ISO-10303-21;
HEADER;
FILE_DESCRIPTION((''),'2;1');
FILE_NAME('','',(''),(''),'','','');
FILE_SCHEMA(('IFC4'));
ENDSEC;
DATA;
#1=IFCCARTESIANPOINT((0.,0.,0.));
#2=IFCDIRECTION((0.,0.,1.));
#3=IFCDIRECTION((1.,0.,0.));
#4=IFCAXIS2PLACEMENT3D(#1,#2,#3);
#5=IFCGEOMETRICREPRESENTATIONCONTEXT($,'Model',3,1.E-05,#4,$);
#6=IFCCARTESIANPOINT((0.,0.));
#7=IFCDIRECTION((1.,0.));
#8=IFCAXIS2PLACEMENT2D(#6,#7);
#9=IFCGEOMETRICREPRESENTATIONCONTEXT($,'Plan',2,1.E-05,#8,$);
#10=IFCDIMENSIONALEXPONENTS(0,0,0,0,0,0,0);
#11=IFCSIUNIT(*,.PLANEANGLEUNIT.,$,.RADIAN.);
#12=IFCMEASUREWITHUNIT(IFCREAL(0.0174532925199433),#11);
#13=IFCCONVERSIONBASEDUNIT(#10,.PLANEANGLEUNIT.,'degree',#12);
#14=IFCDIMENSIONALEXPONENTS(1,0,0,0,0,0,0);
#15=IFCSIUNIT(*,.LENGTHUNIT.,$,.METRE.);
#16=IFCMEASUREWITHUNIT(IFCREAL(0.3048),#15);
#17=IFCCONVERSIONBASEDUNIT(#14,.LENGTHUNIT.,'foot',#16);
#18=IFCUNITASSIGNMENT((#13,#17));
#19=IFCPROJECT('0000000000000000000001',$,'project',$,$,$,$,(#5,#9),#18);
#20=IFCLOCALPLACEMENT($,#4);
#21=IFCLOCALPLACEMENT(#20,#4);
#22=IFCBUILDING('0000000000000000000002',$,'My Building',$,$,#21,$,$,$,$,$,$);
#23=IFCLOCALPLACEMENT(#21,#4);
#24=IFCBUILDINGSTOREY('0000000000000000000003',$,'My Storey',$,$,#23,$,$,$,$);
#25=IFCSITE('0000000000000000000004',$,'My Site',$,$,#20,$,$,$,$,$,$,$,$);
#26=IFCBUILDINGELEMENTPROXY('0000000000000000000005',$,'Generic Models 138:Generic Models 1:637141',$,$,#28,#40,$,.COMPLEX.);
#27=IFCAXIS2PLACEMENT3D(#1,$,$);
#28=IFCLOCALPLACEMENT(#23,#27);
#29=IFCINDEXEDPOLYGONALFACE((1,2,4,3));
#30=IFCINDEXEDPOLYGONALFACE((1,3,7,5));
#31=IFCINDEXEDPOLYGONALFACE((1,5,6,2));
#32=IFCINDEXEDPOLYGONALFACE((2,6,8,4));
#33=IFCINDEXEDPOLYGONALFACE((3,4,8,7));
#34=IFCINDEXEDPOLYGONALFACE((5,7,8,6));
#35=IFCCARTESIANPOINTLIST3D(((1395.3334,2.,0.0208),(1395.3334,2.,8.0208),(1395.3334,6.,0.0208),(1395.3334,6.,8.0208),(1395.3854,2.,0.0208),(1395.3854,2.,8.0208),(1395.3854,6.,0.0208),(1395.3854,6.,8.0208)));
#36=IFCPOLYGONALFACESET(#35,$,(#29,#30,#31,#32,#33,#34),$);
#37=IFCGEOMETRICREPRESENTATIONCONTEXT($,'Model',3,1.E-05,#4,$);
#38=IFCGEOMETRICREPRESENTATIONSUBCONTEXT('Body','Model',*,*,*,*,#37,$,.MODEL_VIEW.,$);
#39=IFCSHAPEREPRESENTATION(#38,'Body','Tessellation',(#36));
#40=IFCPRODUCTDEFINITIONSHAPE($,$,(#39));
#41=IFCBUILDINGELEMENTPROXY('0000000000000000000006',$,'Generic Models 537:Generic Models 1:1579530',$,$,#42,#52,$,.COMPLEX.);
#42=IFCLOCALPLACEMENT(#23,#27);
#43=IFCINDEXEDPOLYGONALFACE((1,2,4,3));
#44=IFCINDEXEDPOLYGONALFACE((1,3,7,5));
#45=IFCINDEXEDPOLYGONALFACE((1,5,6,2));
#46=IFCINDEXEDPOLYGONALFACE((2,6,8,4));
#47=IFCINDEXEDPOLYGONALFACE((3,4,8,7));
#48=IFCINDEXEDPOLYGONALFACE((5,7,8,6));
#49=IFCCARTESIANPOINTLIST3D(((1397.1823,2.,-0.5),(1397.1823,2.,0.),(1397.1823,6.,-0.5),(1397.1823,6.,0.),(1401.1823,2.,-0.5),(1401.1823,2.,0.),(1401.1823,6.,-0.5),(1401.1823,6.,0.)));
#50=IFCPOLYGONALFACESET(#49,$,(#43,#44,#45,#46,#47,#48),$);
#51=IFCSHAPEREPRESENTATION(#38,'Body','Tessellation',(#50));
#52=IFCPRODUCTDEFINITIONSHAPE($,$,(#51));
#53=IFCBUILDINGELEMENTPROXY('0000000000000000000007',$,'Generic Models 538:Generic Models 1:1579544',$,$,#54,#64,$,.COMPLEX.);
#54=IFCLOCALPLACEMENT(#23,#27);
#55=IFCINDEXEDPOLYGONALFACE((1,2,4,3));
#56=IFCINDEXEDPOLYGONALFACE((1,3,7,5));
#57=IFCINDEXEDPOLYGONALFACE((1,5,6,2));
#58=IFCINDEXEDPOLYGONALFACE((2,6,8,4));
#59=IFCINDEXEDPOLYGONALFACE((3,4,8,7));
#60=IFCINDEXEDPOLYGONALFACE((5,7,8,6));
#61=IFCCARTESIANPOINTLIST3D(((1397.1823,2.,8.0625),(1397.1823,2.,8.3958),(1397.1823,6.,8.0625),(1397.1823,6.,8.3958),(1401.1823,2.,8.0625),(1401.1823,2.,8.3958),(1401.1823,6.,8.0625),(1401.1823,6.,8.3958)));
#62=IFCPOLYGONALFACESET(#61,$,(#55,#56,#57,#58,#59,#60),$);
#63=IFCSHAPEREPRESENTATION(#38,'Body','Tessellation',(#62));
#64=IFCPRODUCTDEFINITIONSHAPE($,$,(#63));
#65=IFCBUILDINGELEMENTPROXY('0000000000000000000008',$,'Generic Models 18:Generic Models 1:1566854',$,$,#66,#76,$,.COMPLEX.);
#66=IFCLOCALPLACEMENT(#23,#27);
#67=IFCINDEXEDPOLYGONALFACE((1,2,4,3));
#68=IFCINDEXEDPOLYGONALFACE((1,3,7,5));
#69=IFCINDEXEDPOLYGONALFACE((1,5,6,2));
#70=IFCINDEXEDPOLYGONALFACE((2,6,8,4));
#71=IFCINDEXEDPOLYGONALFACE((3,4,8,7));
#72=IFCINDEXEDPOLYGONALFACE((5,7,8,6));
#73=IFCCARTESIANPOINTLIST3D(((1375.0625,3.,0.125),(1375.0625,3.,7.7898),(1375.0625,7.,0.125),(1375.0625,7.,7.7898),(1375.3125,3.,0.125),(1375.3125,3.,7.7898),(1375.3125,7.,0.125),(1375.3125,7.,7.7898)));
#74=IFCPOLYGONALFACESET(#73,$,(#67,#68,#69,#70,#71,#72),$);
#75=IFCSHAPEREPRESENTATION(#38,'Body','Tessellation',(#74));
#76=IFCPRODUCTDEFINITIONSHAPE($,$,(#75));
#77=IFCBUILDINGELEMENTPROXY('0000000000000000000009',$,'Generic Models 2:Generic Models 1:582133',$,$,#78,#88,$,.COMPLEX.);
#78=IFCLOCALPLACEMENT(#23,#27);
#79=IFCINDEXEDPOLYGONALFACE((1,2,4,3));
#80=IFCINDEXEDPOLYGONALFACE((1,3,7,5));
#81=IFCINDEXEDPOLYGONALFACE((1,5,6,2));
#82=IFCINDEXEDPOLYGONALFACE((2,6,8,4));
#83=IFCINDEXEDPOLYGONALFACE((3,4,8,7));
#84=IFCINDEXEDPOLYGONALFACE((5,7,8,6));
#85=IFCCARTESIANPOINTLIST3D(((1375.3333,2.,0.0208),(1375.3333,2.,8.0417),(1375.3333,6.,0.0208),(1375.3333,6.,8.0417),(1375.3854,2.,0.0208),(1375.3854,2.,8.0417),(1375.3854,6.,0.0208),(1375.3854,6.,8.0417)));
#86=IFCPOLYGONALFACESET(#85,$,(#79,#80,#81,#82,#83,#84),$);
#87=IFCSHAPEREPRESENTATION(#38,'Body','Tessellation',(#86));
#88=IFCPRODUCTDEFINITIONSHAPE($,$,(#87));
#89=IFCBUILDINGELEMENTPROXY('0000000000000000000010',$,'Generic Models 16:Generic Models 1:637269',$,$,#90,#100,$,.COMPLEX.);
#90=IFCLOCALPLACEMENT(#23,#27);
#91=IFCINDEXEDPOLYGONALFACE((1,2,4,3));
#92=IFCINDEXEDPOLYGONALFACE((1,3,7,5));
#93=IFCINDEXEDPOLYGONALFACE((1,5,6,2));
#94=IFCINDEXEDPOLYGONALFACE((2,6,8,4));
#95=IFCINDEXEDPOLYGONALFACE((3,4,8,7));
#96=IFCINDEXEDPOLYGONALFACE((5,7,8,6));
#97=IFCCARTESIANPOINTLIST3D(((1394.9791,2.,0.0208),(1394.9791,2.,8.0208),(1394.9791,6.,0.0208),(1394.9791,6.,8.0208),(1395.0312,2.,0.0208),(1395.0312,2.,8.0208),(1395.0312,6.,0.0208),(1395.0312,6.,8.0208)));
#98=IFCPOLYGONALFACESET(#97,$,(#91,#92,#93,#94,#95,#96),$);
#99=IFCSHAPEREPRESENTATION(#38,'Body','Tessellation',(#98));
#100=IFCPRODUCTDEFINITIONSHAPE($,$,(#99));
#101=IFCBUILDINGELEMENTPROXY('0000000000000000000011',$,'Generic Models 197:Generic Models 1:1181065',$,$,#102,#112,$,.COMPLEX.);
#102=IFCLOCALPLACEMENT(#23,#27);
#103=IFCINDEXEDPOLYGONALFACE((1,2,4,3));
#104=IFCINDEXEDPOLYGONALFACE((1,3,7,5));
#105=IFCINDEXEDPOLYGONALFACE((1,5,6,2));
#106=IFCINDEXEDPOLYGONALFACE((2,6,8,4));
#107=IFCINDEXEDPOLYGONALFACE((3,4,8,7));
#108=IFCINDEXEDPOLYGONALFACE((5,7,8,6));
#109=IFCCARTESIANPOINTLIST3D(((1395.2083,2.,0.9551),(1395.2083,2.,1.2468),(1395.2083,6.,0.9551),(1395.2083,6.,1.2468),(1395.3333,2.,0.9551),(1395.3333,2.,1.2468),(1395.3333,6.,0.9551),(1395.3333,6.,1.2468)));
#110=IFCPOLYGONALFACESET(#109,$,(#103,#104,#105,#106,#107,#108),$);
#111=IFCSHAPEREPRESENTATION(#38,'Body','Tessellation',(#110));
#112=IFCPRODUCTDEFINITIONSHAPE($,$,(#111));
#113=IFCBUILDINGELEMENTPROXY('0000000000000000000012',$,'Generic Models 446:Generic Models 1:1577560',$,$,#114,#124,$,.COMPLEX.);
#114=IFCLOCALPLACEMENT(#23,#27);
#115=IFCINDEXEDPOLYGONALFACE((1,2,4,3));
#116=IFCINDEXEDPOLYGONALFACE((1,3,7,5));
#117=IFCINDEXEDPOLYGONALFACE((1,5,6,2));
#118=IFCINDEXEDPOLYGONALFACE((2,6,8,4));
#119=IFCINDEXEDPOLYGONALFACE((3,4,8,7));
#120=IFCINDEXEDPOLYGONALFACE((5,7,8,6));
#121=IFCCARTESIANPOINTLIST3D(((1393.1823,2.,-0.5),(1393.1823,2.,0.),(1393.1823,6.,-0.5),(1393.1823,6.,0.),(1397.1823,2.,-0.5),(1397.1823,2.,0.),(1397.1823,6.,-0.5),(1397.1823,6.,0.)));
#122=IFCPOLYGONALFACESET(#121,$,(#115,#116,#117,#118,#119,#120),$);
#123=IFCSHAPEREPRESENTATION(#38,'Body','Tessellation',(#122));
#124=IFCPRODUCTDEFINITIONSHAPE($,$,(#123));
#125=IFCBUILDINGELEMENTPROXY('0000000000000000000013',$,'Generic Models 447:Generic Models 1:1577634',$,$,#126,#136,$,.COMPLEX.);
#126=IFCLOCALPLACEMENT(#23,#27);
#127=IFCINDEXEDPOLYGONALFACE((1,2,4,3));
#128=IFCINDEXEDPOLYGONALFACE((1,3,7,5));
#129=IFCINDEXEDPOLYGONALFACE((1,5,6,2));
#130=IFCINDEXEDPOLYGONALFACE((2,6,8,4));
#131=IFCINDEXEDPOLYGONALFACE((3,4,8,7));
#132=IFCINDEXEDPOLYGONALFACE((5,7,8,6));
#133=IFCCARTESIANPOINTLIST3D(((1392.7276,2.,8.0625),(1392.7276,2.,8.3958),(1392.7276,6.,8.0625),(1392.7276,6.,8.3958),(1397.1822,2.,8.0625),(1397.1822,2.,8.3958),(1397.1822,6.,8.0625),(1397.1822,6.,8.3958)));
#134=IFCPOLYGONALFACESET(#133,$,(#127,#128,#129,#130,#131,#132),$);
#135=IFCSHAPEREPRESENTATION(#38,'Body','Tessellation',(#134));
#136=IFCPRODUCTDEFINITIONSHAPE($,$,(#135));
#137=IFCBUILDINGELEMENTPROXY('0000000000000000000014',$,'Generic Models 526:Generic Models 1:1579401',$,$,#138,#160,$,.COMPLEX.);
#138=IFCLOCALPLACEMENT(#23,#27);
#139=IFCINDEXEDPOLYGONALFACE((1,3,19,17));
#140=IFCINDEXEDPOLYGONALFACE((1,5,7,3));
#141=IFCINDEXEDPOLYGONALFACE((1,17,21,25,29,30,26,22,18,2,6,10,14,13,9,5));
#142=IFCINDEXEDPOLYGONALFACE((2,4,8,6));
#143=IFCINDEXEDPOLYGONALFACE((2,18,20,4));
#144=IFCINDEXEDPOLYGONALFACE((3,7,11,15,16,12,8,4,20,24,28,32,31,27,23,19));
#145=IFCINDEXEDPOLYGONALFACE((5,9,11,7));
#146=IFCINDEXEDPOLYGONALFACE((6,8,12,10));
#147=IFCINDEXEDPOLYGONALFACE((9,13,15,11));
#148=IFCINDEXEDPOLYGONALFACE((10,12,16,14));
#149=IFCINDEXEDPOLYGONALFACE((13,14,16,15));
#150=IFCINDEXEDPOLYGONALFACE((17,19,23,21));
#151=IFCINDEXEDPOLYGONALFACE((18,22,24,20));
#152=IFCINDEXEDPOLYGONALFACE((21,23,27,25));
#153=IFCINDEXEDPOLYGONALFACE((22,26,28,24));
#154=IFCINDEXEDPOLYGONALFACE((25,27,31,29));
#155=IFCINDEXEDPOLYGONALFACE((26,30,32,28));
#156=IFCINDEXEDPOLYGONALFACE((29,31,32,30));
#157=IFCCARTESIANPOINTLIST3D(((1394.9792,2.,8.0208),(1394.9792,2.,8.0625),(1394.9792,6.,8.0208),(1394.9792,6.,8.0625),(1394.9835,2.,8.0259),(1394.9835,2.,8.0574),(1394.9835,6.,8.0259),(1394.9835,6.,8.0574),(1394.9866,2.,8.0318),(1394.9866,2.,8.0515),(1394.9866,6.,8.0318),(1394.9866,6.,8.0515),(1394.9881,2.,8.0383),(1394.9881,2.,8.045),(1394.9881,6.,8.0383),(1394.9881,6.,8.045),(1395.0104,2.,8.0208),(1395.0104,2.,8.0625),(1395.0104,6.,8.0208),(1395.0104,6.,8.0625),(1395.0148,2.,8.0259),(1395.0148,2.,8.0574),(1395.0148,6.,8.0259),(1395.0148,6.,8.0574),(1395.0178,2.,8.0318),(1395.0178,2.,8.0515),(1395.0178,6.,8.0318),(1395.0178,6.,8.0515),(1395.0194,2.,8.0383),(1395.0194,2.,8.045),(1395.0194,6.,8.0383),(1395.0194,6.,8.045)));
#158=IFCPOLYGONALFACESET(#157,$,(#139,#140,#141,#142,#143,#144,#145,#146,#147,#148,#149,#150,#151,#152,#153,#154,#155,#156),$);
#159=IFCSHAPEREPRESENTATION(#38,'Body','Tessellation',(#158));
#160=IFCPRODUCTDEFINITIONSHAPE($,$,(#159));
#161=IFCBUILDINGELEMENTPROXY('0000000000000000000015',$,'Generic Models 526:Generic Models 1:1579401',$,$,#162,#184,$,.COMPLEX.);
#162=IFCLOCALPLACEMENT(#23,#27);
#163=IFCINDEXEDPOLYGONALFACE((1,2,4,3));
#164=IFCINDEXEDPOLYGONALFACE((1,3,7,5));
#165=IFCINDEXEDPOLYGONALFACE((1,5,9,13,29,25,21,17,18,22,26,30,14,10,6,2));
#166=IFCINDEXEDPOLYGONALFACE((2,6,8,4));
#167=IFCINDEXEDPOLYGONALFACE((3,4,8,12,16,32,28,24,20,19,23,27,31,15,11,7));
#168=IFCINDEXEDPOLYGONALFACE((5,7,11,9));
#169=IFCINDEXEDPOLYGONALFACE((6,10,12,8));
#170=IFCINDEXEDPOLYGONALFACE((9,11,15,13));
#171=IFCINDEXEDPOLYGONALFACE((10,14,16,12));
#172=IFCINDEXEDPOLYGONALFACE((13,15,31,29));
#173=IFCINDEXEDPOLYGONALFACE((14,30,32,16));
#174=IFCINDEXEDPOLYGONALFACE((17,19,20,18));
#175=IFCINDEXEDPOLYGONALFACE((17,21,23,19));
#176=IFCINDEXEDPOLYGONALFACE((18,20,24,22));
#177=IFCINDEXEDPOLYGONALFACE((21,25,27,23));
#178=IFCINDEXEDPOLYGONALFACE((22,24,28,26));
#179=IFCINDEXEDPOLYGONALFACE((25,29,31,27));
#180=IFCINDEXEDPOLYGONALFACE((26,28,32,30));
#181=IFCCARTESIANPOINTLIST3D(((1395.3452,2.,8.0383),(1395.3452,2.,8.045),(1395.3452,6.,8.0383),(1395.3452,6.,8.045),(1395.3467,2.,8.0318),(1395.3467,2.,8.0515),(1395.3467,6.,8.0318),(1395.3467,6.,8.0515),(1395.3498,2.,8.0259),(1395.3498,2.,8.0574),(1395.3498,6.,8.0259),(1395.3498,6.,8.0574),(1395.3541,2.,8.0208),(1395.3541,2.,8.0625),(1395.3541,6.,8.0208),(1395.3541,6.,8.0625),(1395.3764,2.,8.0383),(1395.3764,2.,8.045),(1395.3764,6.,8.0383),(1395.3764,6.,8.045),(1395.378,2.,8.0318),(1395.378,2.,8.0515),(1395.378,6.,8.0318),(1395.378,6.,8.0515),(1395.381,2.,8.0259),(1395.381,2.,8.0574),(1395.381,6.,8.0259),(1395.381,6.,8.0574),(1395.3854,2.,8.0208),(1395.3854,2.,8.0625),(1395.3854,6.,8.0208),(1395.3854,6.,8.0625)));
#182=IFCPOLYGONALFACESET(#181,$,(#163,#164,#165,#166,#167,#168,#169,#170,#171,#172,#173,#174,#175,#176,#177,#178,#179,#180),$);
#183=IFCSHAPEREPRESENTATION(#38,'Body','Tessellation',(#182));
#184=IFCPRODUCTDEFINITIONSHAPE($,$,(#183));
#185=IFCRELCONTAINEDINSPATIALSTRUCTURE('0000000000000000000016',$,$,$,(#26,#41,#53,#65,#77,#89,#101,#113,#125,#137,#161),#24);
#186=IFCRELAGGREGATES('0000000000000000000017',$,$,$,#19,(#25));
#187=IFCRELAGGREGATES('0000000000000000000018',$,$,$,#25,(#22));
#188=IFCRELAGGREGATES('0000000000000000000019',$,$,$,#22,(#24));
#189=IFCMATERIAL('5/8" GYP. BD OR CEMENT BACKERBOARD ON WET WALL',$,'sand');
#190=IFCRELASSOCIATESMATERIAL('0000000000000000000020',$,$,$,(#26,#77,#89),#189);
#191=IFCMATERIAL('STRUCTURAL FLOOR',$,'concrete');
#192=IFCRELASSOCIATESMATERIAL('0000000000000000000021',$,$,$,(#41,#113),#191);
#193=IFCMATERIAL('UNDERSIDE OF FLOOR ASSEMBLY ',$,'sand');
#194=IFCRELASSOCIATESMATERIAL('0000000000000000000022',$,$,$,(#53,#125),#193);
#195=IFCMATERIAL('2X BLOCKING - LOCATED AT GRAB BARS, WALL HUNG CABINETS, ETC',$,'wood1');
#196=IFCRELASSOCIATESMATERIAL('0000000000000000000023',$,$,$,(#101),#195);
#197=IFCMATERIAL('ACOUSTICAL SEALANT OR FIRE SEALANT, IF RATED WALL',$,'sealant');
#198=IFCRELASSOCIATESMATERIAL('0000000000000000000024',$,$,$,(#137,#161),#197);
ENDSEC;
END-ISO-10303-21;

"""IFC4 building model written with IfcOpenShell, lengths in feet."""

from ifc_helpers import new_model, entity, si_unit, converted_unit, frame, origin_with_axes, origin_2d_with_axis, place, context, subcontext, project, spatial, polyline, line, indexed_curve, outline, extrude, material, element, save


model = new_model("IFC4")

# Units and contexts
model_context_1 = context("Model", 3, precision=1e-05, world=origin_with_axes())
plan_context = context("Plan", 2, precision=1e-05, world=origin_2d_with_axis())
model_context_2 = context("Model", 3, precision=1e-05, world=origin_with_axes())
body_context = subcontext(model_context_2, "Body", "Model", "MODEL_VIEW")
ifc_project = project(units=[converted_unit("PLANEANGLEUNIT", "degree", entity("IfcReal", 0.0174532925199433), si_unit("PLANEANGLEUNIT", "RADIAN"), dimensions=[0, 0, 0, 0, 0, 0, 0]), converted_unit("LENGTHUNIT", "foot", entity("IfcReal", 0.3048), si_unit("LENGTHUNIT", "METRE"), dimensions=[1, 0, 0, 0, 0, 0, 0])], contexts=[model_context_1, plan_context])

# Site, building, storey
site_placement = place(None, origin_with_axes())
site = spatial("IfcSite", under=ifc_project, at=site_placement, Name="My Site")
building_placement = place(site_placement, origin_with_axes())
building = spatial("IfcBuilding", under=site, at=building_placement, Name="My Building")
storey_placement = place(building_placement, origin_with_axes())
storey = spatial("IfcBuildingStorey", under=building, at=storey_placement, Name="My Storey")

# Building element proxies
ifc_material_1 = material(Name="5/8\" GYP. BD OR CEMENT BACKERBOARD ON WET WALL", Category="sand")
proxy_1_placement = place(storey_placement, frame((1395.3334, 6.0, 0.0208), z_axis=(0.0, -1.0, 0.0), x_axis=(0.0, 0.0, 1.0)))
element("IfcBuildingElementProxy", 1, at=proxy_1_placement, inside=storey, material=ifc_material_1, Name="Generic Models 138:Generic Models 1:637141", PredefinedType="COMPLEX", context=body_context, shape_type="SweptSolid", body=[
    extrude(outline(polyline([(-0.026, -4.0), (0.026, -4.0), (0.026, 4.0), (-0.026, 4.0), (-0.026, -4.0)])), frame((4.0, -0.026, 0.0), z_axis=(0.0, 0.0, -1.0), x_axis=(0.0, 1.0, 0.0)), (0.0, 0.0, -1.0), 4.0),
])
ifc_material_2 = material(Name="STRUCTURAL FLOOR", Category="concrete")
proxy_2_placement = place(storey_placement, frame((1397.1823, 6.0, -0.5), z_axis=(0.0, -1.0, 0.0), x_axis=(0.0, 0.0, 1.0)))
element("IfcBuildingElementProxy", 2, at=proxy_2_placement, inside=storey, material=ifc_material_2, Name="Generic Models 537:Generic Models 1:1579530", PredefinedType="COMPLEX", context=body_context, shape_type="SweptSolid", body=[
    extrude(outline(polyline([(-0.25, -2.0), (0.25, -2.0), (0.25, 2.0), (-0.25, 2.0), (-0.25, -2.0)])), frame((0.25, -2.0, 0.0), z_axis=(0.0, 0.0, -1.0), x_axis=(1.0, 0.0, 0.0)), (0.0, 0.0, -1.0), 4.0),
])
ifc_material_3 = material(Name="UNDERSIDE OF FLOOR ASSEMBLY ", Category="sand")
proxy_3_placement = place(storey_placement, frame((1397.1823, 6.0, 8.0625), z_axis=(0.0, -1.0, 0.0), x_axis=(0.0, 0.0, 1.0)))
element("IfcBuildingElementProxy", 3, at=proxy_3_placement, inside=storey, material=ifc_material_3, Name="Generic Models 538:Generic Models 1:1579544", PredefinedType="COMPLEX", context=body_context, shape_type="SweptSolid", body=[
    extrude(outline(polyline([(-0.1667, -2.0), (0.1667, -2.0), (0.1667, 2.0), (-0.1667, 2.0), (-0.1667, -2.0)])), frame((0.1667, -2.0, 0.0), z_axis=(0.0, 0.0, -1.0), x_axis=(1.0, 0.0, 0.0)), (0.0, 0.0, -1.0), 4.0),
])
proxy_4_placement = place(storey_placement, frame((1375.0625, 3.0, 0.125), z_axis=(0.0, 1.0, 0.0), x_axis=(0.0, 0.0, -1.0)))
element("IfcBuildingElementProxy", 4, at=proxy_4_placement, inside=storey, Name="Generic Models 18:Generic Models 1:1566854", PredefinedType="COMPLEX", context=body_context, shape_type="SweptSolid", body=[
    extrude(outline(polyline([(-3.8324, -0.125), (3.8324, -0.125), (3.8324, 0.125), (-3.8324, 0.125), (-3.8324, -0.125)])), frame((-3.8324, -0.125, 0.0), z_axis=(0.0, 0.0, -1.0), x_axis=(1.0, 0.0, 0.0)), (0.0, 0.0, -1.0), 4.0),
])
proxy_5_placement = place(storey_placement, frame((1375.3333, 6.0, 0.0208), z_axis=(0.0, -1.0, 0.0), x_axis=(0.0, 0.0, -1.0)))
element("IfcBuildingElementProxy", 5, at=proxy_5_placement, inside=storey, material=ifc_material_1, Name="Generic Models 2:Generic Models 1:582133", PredefinedType="COMPLEX", context=body_context, shape_type="SweptSolid", body=[
    extrude(outline(polyline([(-4.0104, -0.026), (4.0104, -0.026), (4.0104, 0.026), (-4.0104, 0.026), (-4.0104, -0.026)])), frame((-4.0104, 0.026, 0.0), z_axis=(0.0, 0.0, -1.0), x_axis=(1.0, 0.0, 0.0)), (0.0, 0.0, -1.0), 4.0),
])
proxy_6_placement = place(storey_placement, frame((1394.9791, 6.0, 0.0208), z_axis=(0.0, -1.0, 0.0), x_axis=(0.0, 0.0, 1.0)))
element("IfcBuildingElementProxy", 6, at=proxy_6_placement, inside=storey, material=ifc_material_1, Name="Generic Models 16:Generic Models 1:637269", PredefinedType="COMPLEX", context=body_context, shape_type="SweptSolid", body=[
    extrude(outline(polyline([(-0.026, -4.0), (0.026, -4.0), (0.026, 4.0), (-0.026, 4.0), (-0.026, -4.0)])), frame((4.0, -0.026, 0.0), z_axis=(0.0, 0.0, -1.0), x_axis=(0.0, 1.0, 0.0)), (0.0, 0.0, -1.0), 4.0),
])
ifc_material_4 = material(Name="ACOUSTICAL SEALANT OR FIRE SEALANT, IF RATED WALL", Category="sealant")
ifc_material_5 = material(Name="2X BLOCKING - LOCATED AT GRAB BARS, WALL HUNG CABINETS, ETC", Category="wood1")
proxy_7_placement = place(storey_placement, frame((1395.2083, 6.0, 0.9551), z_axis=(0.0, -1.0, 0.0), x_axis=(0.0, 0.0, 1.0)))
element("IfcBuildingElementProxy", 7, at=proxy_7_placement, inside=storey, material=ifc_material_5, Name="Generic Models 197:Generic Models 1:1181065", PredefinedType="COMPLEX", context=body_context, shape_type="SweptSolid", body=[
    extrude(outline(polyline([(-0.0625, -0.1458), (0.0625, -0.1458), (0.0625, 0.1458), (-0.0625, 0.1458), (-0.0625, -0.1458)])), frame((0.1458, -0.0625, 0.0), z_axis=(0.0, 0.0, -1.0), x_axis=(0.0, -1.0, 0.0)), (0.0, 0.0, -1.0), 4.0),
])
proxy_8_placement = place(storey_placement, frame((1393.1823, 6.0, -0.5), z_axis=(0.0, -1.0, 0.0), x_axis=(0.0, 0.0, 1.0)))
element("IfcBuildingElementProxy", 8, at=proxy_8_placement, inside=storey, material=ifc_material_2, Name="Generic Models 446:Generic Models 1:1577560", PredefinedType="COMPLEX", context=body_context, shape_type="SweptSolid", body=[
    extrude(outline(polyline([(-2.0, -0.25), (2.0, -0.25), (2.0, 0.25), (-2.0, 0.25), (-2.0, -0.25)])), frame((0.25, -2.0, 0.0), z_axis=(0.0, 0.0, -1.0), x_axis=(0.0, 1.0, 0.0)), (0.0, 0.0, -1.0), 4.0),
])
proxy_9_placement = place(storey_placement, frame((1392.7276, 6.0, 8.0625), z_axis=(0.0, -1.0, 0.0), x_axis=(0.0, 0.0, 1.0)))
element("IfcBuildingElementProxy", 9, at=proxy_9_placement, inside=storey, material=ifc_material_3, Name="Generic Models 447:Generic Models 1:1577634", PredefinedType="COMPLEX", context=body_context, shape_type="SweptSolid", body=[
    extrude(outline(indexed_curve([(-2.4546, -0.1667), (2.0, -0.1667), (2.0, 0.1667), (-2.4546, 0.1667)], segments=[line(3, 2), line(2, 1), line(1, 4), line(4, 3)], self_intersect=False)), frame((0.1667, -2.0, 0.0), z_axis=(0.0, 0.0, -1.0), x_axis=(0.0, 1.0, 0.0)), (0.0, 0.0, -1.0), 4.0),
])
for number, where, z_axis, x_axis, name in (
    (10, (1394.9791, 6.0, 8.0208), (0.0, -1.0, 0.0), (0.0, 0.0, 1.0), "Generic Models 526:Generic Models 1:1579401"),
    (11, (1395.3854, 6.0, 8.0625), (0.0, -1.0, 0.0), (0.0, 0.0, -1.0), "Generic Models 526:Generic Models 1:1579401"),
):
    element("IfcBuildingElementProxy", number, at=place(storey_placement, frame(where, z_axis=z_axis, x_axis=x_axis)), inside=storey, material=ifc_material_4, Name=name, PredefinedType="COMPLEX", context=body_context, shape_type="SweptSolid", body=[
        extrude(outline(polyline([(0.0216, 0.0), (0.0223, 0.0066), (0.001, 0.0294), (0.0002, 0.0228), (-0.002, 0.0165), (-0.0057, 0.0109), (-0.0105, 0.0064), (-0.0163, 0.0031), (-0.0228, 0.0012), (-0.0294, 0.0009), (-0.008, -0.0219), (-0.0014, -0.0216), (0.005, -0.0197), (0.0108, -0.0164), (0.0157, -0.0119), (0.0194, -0.0063), (0.0216, 0.0)])), frame((0.0208, -0.0208, 0.0), z_axis=(0.0, 0.0, -1.0), x_axis=(-0.729168, -0.684334, 0.0)), (0.0, 0.0, -1.0), 4.0),
    ])

save(model, "model.ifc")
